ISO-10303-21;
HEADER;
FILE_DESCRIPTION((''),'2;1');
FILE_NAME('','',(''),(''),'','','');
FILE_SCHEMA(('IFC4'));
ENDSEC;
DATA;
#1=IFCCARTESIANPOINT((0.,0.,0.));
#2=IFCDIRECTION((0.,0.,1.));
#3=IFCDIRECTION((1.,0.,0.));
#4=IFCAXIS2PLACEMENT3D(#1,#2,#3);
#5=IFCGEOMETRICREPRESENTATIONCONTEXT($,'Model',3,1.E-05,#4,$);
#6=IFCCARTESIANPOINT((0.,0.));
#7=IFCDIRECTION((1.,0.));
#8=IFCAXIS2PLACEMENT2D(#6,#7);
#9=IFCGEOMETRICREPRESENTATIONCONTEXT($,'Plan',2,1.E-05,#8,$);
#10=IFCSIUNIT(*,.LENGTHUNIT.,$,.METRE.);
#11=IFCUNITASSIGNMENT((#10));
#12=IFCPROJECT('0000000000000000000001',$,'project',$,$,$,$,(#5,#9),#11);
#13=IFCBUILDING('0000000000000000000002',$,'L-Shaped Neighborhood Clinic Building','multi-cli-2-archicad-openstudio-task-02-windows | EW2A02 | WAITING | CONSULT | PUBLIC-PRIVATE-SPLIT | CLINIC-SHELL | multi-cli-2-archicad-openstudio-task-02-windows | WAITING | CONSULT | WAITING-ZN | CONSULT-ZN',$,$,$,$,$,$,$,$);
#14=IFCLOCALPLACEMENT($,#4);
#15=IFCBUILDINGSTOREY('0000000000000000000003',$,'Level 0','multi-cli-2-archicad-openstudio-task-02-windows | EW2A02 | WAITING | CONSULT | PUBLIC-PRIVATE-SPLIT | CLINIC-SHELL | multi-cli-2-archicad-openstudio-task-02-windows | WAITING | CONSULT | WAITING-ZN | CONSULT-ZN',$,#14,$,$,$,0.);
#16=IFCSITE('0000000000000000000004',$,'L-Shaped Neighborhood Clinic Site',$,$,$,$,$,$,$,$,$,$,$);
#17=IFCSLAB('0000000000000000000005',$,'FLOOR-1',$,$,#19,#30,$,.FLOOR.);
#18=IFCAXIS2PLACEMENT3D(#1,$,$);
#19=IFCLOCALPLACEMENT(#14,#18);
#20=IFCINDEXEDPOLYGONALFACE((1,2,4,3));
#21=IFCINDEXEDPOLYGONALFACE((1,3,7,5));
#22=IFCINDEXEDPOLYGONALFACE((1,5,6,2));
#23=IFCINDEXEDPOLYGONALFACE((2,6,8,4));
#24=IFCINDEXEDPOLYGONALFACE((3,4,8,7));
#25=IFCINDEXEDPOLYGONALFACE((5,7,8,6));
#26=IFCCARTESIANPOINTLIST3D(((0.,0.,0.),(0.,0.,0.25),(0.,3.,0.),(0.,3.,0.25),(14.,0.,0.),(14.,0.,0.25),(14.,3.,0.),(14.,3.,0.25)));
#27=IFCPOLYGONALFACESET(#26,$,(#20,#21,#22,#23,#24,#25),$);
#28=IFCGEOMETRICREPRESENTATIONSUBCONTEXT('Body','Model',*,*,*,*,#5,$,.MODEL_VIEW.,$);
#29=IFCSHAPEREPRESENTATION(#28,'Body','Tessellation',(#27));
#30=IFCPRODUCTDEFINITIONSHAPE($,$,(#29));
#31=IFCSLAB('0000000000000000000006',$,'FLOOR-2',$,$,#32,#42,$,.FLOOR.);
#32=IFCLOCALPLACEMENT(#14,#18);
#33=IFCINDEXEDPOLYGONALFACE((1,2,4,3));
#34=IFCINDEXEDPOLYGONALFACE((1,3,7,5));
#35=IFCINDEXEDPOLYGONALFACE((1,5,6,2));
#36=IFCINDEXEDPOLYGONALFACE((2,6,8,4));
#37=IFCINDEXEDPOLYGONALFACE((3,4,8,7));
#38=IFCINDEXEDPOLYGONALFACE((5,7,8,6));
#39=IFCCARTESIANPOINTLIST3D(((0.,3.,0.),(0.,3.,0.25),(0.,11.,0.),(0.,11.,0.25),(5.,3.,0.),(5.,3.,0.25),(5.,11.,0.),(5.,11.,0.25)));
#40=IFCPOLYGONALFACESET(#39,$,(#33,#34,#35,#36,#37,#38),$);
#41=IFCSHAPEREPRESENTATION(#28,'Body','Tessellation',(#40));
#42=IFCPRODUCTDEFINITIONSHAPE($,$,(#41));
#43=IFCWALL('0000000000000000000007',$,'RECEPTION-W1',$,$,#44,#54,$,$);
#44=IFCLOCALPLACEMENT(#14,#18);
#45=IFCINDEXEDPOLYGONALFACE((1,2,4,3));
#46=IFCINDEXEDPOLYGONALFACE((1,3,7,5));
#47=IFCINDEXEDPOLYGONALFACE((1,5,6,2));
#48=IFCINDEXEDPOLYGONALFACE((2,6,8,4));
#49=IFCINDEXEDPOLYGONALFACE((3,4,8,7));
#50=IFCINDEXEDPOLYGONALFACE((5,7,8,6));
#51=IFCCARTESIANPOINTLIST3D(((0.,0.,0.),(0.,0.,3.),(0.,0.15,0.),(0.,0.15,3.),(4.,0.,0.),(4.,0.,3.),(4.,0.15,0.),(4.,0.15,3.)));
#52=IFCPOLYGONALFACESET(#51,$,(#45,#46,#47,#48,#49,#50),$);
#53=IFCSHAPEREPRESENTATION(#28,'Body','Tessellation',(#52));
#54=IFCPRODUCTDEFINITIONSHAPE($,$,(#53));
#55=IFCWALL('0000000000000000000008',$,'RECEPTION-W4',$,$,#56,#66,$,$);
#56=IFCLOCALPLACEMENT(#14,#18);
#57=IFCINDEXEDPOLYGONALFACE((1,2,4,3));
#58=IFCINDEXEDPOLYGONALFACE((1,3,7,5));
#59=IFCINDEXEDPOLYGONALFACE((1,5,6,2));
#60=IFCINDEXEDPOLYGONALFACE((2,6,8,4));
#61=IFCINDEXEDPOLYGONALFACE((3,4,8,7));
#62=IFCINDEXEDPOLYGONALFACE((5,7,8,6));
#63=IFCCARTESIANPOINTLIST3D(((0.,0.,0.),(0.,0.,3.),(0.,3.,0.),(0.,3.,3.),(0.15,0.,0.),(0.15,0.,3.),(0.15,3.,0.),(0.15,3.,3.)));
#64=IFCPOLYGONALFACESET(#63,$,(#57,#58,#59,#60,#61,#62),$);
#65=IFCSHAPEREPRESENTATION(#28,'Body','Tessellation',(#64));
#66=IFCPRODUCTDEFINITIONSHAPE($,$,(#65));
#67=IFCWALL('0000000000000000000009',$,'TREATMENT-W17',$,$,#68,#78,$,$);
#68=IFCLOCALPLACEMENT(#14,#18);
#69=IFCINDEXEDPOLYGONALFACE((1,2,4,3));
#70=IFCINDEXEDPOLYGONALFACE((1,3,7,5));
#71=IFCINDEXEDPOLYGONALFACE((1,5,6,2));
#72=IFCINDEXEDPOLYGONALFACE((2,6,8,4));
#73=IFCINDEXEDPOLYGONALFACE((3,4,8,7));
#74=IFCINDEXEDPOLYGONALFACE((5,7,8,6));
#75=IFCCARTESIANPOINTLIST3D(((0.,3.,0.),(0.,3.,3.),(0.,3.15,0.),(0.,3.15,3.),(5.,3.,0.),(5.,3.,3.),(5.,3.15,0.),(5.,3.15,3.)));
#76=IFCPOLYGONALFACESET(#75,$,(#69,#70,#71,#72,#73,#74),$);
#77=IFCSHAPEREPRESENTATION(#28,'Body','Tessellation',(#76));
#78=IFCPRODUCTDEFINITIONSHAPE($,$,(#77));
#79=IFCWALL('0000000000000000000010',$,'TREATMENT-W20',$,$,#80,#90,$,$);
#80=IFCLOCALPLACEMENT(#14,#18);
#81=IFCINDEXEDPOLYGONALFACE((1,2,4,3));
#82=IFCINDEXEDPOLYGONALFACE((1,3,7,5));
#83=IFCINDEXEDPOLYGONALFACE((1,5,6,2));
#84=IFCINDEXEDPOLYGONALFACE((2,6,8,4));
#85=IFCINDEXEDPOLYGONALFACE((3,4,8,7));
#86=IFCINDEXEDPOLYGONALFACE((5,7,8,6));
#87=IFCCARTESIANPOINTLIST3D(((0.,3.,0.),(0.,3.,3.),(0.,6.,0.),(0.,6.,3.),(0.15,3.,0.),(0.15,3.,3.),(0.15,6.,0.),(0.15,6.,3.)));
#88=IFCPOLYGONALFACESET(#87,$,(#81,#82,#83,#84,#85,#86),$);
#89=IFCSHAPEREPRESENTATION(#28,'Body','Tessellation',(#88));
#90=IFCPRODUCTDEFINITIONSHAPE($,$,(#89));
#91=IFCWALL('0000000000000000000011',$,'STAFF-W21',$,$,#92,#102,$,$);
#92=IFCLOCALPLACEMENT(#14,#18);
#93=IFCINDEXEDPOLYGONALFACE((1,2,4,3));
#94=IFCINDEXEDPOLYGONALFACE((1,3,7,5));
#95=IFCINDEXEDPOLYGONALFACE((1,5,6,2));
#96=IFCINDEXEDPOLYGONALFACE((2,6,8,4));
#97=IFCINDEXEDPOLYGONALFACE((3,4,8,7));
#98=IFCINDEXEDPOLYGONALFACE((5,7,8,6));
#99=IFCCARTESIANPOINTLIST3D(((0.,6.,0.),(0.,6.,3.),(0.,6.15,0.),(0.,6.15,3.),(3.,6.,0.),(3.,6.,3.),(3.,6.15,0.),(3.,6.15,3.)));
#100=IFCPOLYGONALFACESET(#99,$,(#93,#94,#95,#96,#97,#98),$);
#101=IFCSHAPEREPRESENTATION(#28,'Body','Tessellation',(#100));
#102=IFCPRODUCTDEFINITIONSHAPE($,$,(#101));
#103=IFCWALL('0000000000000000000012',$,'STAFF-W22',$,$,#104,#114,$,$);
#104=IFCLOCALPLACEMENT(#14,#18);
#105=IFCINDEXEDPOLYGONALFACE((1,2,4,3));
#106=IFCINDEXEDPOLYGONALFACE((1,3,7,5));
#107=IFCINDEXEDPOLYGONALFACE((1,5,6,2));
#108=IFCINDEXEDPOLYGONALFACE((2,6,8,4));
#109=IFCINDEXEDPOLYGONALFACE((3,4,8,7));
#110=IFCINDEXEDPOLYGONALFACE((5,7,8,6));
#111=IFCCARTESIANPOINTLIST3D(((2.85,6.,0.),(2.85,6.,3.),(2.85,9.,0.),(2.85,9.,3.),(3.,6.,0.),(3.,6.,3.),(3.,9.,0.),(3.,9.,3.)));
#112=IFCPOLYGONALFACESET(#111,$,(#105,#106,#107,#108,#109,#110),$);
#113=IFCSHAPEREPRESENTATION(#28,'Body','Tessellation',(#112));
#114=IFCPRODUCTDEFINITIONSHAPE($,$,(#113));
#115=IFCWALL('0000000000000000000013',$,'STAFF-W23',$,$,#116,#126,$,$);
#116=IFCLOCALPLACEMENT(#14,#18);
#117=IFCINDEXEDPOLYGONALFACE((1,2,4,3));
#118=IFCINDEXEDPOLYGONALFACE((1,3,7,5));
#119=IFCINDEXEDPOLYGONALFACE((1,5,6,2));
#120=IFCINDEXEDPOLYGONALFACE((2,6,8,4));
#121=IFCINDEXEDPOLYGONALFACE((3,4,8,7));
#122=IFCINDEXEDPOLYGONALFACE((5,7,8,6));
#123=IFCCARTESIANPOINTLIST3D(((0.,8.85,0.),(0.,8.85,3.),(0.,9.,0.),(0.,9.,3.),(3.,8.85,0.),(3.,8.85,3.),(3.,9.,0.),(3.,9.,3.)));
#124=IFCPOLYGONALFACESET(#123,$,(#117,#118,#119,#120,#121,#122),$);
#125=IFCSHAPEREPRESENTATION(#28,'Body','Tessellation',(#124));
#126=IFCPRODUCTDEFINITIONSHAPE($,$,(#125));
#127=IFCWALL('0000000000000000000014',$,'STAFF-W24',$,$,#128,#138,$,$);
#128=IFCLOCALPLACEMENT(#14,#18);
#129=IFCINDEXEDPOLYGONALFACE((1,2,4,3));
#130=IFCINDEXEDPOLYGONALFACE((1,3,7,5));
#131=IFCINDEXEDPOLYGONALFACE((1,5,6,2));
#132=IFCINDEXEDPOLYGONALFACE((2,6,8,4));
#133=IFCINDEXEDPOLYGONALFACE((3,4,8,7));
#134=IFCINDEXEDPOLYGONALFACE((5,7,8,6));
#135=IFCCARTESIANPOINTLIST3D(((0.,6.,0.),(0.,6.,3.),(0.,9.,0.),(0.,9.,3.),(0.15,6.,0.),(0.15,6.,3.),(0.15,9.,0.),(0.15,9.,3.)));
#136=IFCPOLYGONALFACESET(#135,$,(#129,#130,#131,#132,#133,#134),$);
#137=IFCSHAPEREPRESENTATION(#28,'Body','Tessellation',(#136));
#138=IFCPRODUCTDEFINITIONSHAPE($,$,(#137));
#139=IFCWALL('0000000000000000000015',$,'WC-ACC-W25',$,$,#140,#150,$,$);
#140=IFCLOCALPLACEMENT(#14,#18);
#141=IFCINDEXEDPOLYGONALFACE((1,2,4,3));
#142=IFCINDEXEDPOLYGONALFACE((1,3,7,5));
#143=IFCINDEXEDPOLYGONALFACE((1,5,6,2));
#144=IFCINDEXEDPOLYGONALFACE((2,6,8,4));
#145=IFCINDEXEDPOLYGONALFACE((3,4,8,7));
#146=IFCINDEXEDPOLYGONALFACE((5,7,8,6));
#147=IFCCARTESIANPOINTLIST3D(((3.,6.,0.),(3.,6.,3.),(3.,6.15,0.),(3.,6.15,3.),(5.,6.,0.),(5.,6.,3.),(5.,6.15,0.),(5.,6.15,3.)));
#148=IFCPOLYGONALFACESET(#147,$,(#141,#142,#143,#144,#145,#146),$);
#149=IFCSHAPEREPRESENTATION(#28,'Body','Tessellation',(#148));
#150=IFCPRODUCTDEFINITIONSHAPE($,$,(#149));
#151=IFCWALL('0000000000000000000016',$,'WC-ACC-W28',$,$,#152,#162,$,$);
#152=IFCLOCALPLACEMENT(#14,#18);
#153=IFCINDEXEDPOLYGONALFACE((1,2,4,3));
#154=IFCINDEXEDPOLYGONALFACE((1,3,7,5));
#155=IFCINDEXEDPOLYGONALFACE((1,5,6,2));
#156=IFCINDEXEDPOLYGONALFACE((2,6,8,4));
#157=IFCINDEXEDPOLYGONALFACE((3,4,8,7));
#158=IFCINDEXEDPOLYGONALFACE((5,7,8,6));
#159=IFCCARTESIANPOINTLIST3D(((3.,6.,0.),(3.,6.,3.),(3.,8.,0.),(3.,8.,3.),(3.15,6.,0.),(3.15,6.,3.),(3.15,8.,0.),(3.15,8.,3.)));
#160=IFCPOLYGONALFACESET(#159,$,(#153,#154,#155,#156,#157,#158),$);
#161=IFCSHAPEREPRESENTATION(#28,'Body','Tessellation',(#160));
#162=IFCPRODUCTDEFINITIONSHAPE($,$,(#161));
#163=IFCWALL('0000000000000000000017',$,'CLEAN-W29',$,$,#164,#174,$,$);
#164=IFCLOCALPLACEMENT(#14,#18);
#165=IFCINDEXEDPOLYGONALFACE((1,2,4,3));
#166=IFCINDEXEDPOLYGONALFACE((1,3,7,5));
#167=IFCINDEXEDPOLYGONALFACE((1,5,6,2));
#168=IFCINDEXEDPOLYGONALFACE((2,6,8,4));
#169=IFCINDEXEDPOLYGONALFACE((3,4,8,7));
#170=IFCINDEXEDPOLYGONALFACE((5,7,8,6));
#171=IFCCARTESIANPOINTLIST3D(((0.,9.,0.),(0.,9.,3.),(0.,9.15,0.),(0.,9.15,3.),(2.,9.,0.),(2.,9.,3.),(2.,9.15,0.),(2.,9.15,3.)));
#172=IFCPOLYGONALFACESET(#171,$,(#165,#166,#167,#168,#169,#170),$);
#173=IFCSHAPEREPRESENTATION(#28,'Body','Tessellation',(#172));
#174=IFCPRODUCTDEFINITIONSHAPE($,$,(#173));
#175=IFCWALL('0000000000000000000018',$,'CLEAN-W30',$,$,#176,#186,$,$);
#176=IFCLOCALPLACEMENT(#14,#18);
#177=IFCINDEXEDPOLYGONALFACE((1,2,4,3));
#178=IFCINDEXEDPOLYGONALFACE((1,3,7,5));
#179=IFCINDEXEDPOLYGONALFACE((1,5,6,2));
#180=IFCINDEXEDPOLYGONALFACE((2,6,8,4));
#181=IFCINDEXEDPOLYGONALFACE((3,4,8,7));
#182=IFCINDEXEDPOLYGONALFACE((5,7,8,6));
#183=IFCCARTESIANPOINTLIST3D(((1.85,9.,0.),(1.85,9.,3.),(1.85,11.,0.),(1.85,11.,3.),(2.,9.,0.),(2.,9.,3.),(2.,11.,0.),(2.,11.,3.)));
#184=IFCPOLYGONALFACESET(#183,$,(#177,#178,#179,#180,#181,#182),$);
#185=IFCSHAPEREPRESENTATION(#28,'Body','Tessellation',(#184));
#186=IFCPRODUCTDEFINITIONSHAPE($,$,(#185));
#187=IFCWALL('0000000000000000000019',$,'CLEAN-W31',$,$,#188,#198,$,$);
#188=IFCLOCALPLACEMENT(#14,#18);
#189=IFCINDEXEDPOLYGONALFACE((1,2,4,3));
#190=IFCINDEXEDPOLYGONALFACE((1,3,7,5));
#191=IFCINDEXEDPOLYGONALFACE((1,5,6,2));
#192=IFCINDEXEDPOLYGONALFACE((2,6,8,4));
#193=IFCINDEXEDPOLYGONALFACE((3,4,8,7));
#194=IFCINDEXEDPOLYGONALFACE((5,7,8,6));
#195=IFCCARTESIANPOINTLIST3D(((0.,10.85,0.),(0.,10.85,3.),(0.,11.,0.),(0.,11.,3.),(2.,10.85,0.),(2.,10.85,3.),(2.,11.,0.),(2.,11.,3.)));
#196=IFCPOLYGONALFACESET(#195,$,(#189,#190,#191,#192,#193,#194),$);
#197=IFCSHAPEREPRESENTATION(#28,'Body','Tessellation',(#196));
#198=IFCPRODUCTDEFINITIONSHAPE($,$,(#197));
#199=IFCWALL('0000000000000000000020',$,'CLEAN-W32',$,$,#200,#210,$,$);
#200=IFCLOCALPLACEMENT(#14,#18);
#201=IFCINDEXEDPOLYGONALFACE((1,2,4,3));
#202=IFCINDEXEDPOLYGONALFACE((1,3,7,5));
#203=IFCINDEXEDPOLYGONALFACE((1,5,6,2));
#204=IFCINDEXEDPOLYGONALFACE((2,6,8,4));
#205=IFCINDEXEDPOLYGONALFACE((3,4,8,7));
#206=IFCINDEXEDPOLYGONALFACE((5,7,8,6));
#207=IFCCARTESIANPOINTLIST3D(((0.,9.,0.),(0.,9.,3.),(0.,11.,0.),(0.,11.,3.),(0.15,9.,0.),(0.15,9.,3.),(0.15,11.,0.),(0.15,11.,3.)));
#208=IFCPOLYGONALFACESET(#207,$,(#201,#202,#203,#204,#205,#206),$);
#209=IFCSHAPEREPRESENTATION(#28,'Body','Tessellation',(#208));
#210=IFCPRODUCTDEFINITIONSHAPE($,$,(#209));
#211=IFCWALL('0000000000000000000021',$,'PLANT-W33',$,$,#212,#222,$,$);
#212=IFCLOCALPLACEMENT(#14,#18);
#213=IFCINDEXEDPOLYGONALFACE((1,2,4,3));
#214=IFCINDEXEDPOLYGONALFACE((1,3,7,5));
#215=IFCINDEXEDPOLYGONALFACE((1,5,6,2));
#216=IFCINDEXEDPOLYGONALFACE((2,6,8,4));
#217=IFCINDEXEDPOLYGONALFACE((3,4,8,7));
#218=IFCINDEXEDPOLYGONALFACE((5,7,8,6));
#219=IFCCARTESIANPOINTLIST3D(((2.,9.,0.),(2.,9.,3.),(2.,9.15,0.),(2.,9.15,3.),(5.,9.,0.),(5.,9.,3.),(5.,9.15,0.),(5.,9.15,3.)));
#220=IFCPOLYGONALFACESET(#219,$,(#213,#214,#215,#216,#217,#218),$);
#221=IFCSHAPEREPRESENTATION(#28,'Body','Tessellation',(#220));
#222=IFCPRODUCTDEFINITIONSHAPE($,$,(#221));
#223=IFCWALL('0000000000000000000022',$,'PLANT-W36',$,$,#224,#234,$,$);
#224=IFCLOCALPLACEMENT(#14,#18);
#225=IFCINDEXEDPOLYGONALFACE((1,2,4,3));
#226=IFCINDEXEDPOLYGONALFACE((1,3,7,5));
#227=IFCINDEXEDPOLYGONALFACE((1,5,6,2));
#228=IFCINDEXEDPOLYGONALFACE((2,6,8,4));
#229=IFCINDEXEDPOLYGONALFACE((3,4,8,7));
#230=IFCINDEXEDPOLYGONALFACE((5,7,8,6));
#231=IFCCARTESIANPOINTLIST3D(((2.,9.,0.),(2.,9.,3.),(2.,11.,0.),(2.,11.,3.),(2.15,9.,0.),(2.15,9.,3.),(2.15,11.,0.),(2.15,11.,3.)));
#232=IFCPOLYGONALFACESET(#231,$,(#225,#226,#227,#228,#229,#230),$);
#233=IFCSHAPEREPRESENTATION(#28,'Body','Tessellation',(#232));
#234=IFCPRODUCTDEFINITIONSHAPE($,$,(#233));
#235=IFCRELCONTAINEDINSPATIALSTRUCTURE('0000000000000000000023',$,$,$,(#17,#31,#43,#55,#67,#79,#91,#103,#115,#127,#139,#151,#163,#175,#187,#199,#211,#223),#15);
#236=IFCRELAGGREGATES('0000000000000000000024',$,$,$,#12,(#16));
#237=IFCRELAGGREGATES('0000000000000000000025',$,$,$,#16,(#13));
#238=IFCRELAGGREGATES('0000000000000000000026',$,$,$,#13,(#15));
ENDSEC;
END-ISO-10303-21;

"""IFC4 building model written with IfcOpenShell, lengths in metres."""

from ifc_helpers import new_model, si_unit, frame, origin_with_axes, origin_2d_with_axis, place, context, subcontext, project, spatial, indexed_curve, outline, extrude, element, save


model = new_model("IFC4")

# Units and contexts
model_context = context("Model", 3, precision=1e-05, world=origin_with_axes())
plan_context = context("Plan", 2, precision=1e-05, world=origin_2d_with_axis())
body_context = subcontext(model_context, "Body", "Model", "MODEL_VIEW")
ifc_project = project(units=[si_unit("LENGTHUNIT", "METRE")], contexts=[model_context, plan_context])

# Site, building, storey
site = spatial("IfcSite", under=ifc_project, Name="L-Shaped Neighborhood Clinic Site")
building = spatial("IfcBuilding", under=site, Name="L-Shaped Neighborhood Clinic Building", Description="multi-cli-2-archicad-openstudio-task-02-windows | EW2A02 | WAITING | CONSULT | PUBLIC-PRIVATE-SPLIT | CLINIC-SHELL | multi-cli-2-archicad-openstudio-task-02-windows | WAITING | CONSULT | WAITING-ZN | CONSULT-ZN")
storey_placement = place(None, origin_with_axes())
storey = spatial("IfcBuildingStorey", under=building, at=storey_placement, Name="Level 0", Description="multi-cli-2-archicad-openstudio-task-02-windows | EW2A02 | WAITING | CONSULT | PUBLIC-PRIVATE-SPLIT | CLINIC-SHELL | multi-cli-2-archicad-openstudio-task-02-windows | WAITING | CONSULT | WAITING-ZN | CONSULT-ZN", Elevation=0.0)

# Slabs
slab_1_placement = place(storey_placement, origin_with_axes())
element("IfcSlab", 1, at=slab_1_placement, inside=storey, Name="FLOOR-1", PredefinedType="FLOOR", context=body_context, shape_type="SweptSolid", body=[
    extrude(outline(indexed_curve([(0.0, 0.0), (14.0, 0.0), (14.0, 3.0), (0.0, 3.0)])), None, (0.0, 0.0, 1.0), 0.25),
])
slab_2_placement = place(storey_placement, origin_with_axes())
element("IfcSlab", 2, at=slab_2_placement, inside=storey, Name="FLOOR-2", PredefinedType="FLOOR", context=body_context, shape_type="SweptSolid", body=[
    extrude(outline(indexed_curve([(0.0, 3.0), (5.0, 3.0), (5.0, 11.0), (0.0, 11.0)])), None, (0.0, 0.0, 1.0), 0.25),
])

# Walls
wall_1_placement = place(storey_placement, origin_with_axes())
element("IfcWall", 3, at=wall_1_placement, inside=storey, Name="RECEPTION-W1", context=body_context, shape_type="SweptSolid", body=[
    extrude(outline(indexed_curve([(0.0, 0.0), (0.0, 0.15), (4.0, 0.15), (4.0, 0.0), (0.0, 0.0)], self_intersect=False)), origin_with_axes(), (0.0, 0.0, 1.0), 3.0),
])
wall_2_placement = place(storey_placement, frame((0.0, 3.0, 0.0), z_axis=(0.0, 0.0, 1.0), x_axis=(0.0, -1.0, 0.0)))
element("IfcWall", 4, at=wall_2_placement, inside=storey, Name="RECEPTION-W4", context=body_context, shape_type="SweptSolid", body=[
    extrude(outline(indexed_curve([(0.0, 0.0), (0.0, 0.15), (3.0, 0.15), (3.0, 0.0), (0.0, 0.0)], self_intersect=False)), origin_with_axes(), (0.0, 0.0, 1.0), 3.0),
])
wall_3_placement = place(storey_placement, frame((0.0, 3.0, 0.0), z_axis=(0.0, 0.0, 1.0), x_axis=(1.0, 0.0, 0.0)))
element("IfcWall", 5, at=wall_3_placement, inside=storey, Name="TREATMENT-W17", context=body_context, shape_type="SweptSolid", body=[
    extrude(outline(indexed_curve([(0.0, 0.0), (0.0, 0.15), (5.0, 0.15), (5.0, 0.0), (0.0, 0.0)], self_intersect=False)), origin_with_axes(), (0.0, 0.0, 1.0), 3.0),
])
for number, where, z_axis, x_axis, name in (
    (6, (0.0, 6.0, 0.0), (0.0, 0.0, 1.0), (0.0, -1.0, 0.0), "TREATMENT-W20"),
    (7, (0.0, 6.0, 0.0), (0.0, 0.0, 1.0), (1.0, 0.0, 0.0), "STAFF-W21"),
    (8, (3.0, 6.0, 0.0), (0.0, 0.0, 1.0), (0.0, 1.0, 0.0), "STAFF-W22"),
    (9, (3.0, 9.0, 0.0), (0.0, 0.0, 1.0), (-1.0, 0.0, 0.0), "STAFF-W23"),
    (10, (0.0, 9.0, 0.0), (0.0, 0.0, 1.0), (0.0, -1.0, 0.0), "STAFF-W24"),
):
    element("IfcWall", number, at=place(storey_placement, frame(where, z_axis=z_axis, x_axis=x_axis)), inside=storey, Name=name, context=body_context, shape_type="SweptSolid", body=[
        extrude(outline(indexed_curve([(0.0, 0.0), (0.0, 0.15), (3.0, 0.15), (3.0, 0.0), (0.0, 0.0)], self_intersect=False)), origin_with_axes(), (0.0, 0.0, 1.0), 3.0),
    ])
for number, where, z_axis, x_axis, name in (
    (11, (3.0, 6.0, 0.0), (0.0, 0.0, 1.0), (1.0, 0.0, 0.0), "WC-ACC-W25"),
    (12, (3.0, 8.0, 0.0), (0.0, 0.0, 1.0), (0.0, -1.0, 0.0), "WC-ACC-W28"),
    (13, (0.0, 9.0, 0.0), (0.0, 0.0, 1.0), (1.0, 0.0, 0.0), "CLEAN-W29"),
    (14, (2.0, 9.0, 0.0), (0.0, 0.0, 1.0), (0.0, 1.0, 0.0), "CLEAN-W30"),
    (15, (2.0, 11.0, 0.0), (0.0, 0.0, 1.0), (-1.0, 0.0, 0.0), "CLEAN-W31"),
    (16, (0.0, 11.0, 0.0), (0.0, 0.0, 1.0), (0.0, -1.0, 0.0), "CLEAN-W32"),
):
    element("IfcWall", number, at=place(storey_placement, frame(where, z_axis=z_axis, x_axis=x_axis)), inside=storey, Name=name, context=body_context, shape_type="SweptSolid", body=[
        extrude(outline(indexed_curve([(0.0, 0.0), (0.0, 0.15), (2.0, 0.15), (2.0, 0.0), (0.0, 0.0)], self_intersect=False)), origin_with_axes(), (0.0, 0.0, 1.0), 3.0),
    ])
wall_4_placement = place(storey_placement, frame((2.0, 9.0, 0.0), z_axis=(0.0, 0.0, 1.0), x_axis=(1.0, 0.0, 0.0)))
element("IfcWall", 17, at=wall_4_placement, inside=storey, Name="PLANT-W33", context=body_context, shape_type="SweptSolid", body=[
    extrude(outline(indexed_curve([(0.0, 0.0), (0.0, 0.15), (3.0, 0.15), (3.0, 0.0), (0.0, 0.0)], self_intersect=False)), origin_with_axes(), (0.0, 0.0, 1.0), 3.0),
])
wall_5_placement = place(storey_placement, frame((2.0, 11.0, 0.0), z_axis=(0.0, 0.0, 1.0), x_axis=(0.0, -1.0, 0.0)))
element("IfcWall", 18, at=wall_5_placement, inside=storey, Name="PLANT-W36", context=body_context, shape_type="SweptSolid", body=[
    extrude(outline(indexed_curve([(0.0, 0.0), (0.0, 0.15), (2.0, 0.15), (2.0, 0.0), (0.0, 0.0)], self_intersect=False)), origin_with_axes(), (0.0, 0.0, 1.0), 3.0),
])

save(model, "model.ifc")
